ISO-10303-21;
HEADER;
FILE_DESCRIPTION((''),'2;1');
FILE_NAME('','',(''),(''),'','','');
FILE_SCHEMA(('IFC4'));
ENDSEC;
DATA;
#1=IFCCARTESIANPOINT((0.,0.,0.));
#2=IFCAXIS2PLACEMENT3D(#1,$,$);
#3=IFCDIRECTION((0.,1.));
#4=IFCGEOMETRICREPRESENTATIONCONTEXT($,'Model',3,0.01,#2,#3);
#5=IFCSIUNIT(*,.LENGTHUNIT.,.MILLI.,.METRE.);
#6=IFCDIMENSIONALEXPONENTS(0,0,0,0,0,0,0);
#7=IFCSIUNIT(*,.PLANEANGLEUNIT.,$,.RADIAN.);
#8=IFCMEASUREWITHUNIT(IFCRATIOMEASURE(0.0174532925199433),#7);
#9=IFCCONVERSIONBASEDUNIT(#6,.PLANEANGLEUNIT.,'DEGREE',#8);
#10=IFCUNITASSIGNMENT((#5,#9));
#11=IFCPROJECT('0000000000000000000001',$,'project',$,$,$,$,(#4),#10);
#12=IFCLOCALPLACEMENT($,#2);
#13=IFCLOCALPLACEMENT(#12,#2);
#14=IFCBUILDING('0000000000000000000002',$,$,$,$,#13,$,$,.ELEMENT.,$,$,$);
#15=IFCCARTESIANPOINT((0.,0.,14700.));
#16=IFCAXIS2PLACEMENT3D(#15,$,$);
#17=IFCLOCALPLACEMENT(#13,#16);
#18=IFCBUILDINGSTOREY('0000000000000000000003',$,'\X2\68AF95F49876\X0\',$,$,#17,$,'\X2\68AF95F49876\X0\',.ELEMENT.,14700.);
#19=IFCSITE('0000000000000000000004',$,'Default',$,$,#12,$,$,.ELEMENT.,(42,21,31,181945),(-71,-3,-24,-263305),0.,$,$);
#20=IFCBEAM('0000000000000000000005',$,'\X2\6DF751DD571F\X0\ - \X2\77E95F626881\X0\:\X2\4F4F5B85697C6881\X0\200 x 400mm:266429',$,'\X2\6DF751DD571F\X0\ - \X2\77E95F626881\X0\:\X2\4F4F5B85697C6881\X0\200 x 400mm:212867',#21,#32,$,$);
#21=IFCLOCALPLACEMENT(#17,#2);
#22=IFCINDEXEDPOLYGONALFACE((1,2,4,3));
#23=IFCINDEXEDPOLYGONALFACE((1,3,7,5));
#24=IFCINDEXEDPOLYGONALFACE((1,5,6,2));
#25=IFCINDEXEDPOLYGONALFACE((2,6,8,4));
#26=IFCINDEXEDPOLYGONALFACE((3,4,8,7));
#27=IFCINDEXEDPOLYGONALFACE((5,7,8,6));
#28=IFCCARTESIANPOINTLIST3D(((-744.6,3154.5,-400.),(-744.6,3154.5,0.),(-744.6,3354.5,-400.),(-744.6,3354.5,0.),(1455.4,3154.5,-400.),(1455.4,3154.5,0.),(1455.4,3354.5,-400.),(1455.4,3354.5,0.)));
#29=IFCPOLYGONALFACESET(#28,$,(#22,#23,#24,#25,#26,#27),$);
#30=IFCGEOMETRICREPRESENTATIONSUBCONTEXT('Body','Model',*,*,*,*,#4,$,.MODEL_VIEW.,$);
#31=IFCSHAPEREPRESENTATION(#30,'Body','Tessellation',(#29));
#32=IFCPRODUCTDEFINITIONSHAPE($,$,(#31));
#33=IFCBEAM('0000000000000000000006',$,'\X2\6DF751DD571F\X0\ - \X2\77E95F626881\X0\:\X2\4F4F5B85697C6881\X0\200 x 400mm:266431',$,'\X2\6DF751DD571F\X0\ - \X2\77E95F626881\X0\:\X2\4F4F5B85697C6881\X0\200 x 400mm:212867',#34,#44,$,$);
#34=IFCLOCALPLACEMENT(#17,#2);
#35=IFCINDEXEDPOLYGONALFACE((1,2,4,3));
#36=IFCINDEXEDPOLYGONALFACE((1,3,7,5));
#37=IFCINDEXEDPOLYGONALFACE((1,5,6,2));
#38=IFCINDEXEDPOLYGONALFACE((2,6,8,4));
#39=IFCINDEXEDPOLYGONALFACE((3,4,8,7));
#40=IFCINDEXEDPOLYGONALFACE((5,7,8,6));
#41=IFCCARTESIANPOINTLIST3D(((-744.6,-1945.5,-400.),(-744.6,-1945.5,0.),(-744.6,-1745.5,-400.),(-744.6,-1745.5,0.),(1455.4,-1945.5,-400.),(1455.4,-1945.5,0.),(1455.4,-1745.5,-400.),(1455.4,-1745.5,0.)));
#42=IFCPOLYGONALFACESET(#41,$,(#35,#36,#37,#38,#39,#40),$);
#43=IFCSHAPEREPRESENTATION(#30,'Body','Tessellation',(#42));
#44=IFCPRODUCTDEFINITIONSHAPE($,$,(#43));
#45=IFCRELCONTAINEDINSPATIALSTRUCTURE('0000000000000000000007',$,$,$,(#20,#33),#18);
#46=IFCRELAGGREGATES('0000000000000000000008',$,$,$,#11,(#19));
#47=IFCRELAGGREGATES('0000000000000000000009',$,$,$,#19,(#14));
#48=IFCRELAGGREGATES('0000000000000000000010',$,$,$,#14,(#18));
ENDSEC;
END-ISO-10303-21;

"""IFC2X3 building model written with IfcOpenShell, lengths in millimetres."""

from ifc_helpers import new_model, entity, si_unit, converted_unit, direction, frame, frame_2d, origin, place, context, subcontext, project, spatial, rectangle, extrude, element, save


model = new_model("IFC2X3")

# Units and contexts
model_context = context("Model", 3, precision=0.01, world=origin(), true_north=direction((0.0, 1.0)))
body_context = subcontext(model_context, "Body", "Model", "MODEL_VIEW")
ifc_project = project(units=[si_unit("LENGTHUNIT", "METRE", prefix="MILLI"), converted_unit("PLANEANGLEUNIT", "DEGREE", entity("IfcRatioMeasure", 0.0174532925199433), si_unit("PLANEANGLEUNIT", "RADIAN"), dimensions=[0, 0, 0, 0, 0, 0, 0])], contexts=[model_context])

# Site, building, storey
site_placement = place(None, origin())
site = spatial("IfcSite", under=ifc_project, at=site_placement, Name="Default", CompositionType="ELEMENT", RefLatitude=(42, 21, 31, 181945), RefLongitude=(-71, -3, -24, -263305), RefElevation=0.0)
building_placement = place(site_placement, origin())
building = spatial("IfcBuilding", under=site, at=building_placement, CompositionType="ELEMENT")
storey_placement = place(building_placement, frame((0.0, 0.0, 14700.0)))
storey = spatial("IfcBuildingStorey", under=building, at=storey_placement, Name="梯间顶", LongName="梯间顶", CompositionType="ELEMENT", Elevation=14700.0)

# Beams
beam_1_placement = place(storey_placement, frame((-944.6, 3254.5, 0.0)))
element("IfcBeam", 1, at=beam_1_placement, inside=storey, Name="混凝土 - 矩形梁:住宅楼梁200 x 400mm:266429", ObjectType="混凝土 - 矩形梁:住宅楼梁200 x 400mm:212867", context=body_context, shape_type="SweptSolid", body=[
    extrude(rectangle(XDim=400.0, YDim=200.0, at=frame_2d((0.0, 0.0), x_axis=(1.0, 0.0))), frame((200.0, 0.0, -200.0), z_axis=(1.0, 0.0, 0.0), x_axis=(0.0, 0.0, -1.0)), (0.0, 0.0, 1.0), 2200.0),
])
beam_2_placement = place(storey_placement, frame((-944.6, -1845.5, 0.0)))
element("IfcBeam", 2, at=beam_2_placement, inside=storey, Name="混凝土 - 矩形梁:住宅楼梁200 x 400mm:266431", ObjectType="混凝土 - 矩形梁:住宅楼梁200 x 400mm:212867", context=body_context, shape_type="SweptSolid", body=[
    extrude(rectangle(XDim=400.0, YDim=200.0, at=frame_2d((0.0, 0.0), x_axis=(1.0, 0.0))), frame((200.0, 0.0, -200.0), z_axis=(1.0, 0.0, 0.0), x_axis=(0.0, 0.0, -1.0)), (0.0, 0.0, 1.0), 2200.0),
])

save(model, "model.ifc")
